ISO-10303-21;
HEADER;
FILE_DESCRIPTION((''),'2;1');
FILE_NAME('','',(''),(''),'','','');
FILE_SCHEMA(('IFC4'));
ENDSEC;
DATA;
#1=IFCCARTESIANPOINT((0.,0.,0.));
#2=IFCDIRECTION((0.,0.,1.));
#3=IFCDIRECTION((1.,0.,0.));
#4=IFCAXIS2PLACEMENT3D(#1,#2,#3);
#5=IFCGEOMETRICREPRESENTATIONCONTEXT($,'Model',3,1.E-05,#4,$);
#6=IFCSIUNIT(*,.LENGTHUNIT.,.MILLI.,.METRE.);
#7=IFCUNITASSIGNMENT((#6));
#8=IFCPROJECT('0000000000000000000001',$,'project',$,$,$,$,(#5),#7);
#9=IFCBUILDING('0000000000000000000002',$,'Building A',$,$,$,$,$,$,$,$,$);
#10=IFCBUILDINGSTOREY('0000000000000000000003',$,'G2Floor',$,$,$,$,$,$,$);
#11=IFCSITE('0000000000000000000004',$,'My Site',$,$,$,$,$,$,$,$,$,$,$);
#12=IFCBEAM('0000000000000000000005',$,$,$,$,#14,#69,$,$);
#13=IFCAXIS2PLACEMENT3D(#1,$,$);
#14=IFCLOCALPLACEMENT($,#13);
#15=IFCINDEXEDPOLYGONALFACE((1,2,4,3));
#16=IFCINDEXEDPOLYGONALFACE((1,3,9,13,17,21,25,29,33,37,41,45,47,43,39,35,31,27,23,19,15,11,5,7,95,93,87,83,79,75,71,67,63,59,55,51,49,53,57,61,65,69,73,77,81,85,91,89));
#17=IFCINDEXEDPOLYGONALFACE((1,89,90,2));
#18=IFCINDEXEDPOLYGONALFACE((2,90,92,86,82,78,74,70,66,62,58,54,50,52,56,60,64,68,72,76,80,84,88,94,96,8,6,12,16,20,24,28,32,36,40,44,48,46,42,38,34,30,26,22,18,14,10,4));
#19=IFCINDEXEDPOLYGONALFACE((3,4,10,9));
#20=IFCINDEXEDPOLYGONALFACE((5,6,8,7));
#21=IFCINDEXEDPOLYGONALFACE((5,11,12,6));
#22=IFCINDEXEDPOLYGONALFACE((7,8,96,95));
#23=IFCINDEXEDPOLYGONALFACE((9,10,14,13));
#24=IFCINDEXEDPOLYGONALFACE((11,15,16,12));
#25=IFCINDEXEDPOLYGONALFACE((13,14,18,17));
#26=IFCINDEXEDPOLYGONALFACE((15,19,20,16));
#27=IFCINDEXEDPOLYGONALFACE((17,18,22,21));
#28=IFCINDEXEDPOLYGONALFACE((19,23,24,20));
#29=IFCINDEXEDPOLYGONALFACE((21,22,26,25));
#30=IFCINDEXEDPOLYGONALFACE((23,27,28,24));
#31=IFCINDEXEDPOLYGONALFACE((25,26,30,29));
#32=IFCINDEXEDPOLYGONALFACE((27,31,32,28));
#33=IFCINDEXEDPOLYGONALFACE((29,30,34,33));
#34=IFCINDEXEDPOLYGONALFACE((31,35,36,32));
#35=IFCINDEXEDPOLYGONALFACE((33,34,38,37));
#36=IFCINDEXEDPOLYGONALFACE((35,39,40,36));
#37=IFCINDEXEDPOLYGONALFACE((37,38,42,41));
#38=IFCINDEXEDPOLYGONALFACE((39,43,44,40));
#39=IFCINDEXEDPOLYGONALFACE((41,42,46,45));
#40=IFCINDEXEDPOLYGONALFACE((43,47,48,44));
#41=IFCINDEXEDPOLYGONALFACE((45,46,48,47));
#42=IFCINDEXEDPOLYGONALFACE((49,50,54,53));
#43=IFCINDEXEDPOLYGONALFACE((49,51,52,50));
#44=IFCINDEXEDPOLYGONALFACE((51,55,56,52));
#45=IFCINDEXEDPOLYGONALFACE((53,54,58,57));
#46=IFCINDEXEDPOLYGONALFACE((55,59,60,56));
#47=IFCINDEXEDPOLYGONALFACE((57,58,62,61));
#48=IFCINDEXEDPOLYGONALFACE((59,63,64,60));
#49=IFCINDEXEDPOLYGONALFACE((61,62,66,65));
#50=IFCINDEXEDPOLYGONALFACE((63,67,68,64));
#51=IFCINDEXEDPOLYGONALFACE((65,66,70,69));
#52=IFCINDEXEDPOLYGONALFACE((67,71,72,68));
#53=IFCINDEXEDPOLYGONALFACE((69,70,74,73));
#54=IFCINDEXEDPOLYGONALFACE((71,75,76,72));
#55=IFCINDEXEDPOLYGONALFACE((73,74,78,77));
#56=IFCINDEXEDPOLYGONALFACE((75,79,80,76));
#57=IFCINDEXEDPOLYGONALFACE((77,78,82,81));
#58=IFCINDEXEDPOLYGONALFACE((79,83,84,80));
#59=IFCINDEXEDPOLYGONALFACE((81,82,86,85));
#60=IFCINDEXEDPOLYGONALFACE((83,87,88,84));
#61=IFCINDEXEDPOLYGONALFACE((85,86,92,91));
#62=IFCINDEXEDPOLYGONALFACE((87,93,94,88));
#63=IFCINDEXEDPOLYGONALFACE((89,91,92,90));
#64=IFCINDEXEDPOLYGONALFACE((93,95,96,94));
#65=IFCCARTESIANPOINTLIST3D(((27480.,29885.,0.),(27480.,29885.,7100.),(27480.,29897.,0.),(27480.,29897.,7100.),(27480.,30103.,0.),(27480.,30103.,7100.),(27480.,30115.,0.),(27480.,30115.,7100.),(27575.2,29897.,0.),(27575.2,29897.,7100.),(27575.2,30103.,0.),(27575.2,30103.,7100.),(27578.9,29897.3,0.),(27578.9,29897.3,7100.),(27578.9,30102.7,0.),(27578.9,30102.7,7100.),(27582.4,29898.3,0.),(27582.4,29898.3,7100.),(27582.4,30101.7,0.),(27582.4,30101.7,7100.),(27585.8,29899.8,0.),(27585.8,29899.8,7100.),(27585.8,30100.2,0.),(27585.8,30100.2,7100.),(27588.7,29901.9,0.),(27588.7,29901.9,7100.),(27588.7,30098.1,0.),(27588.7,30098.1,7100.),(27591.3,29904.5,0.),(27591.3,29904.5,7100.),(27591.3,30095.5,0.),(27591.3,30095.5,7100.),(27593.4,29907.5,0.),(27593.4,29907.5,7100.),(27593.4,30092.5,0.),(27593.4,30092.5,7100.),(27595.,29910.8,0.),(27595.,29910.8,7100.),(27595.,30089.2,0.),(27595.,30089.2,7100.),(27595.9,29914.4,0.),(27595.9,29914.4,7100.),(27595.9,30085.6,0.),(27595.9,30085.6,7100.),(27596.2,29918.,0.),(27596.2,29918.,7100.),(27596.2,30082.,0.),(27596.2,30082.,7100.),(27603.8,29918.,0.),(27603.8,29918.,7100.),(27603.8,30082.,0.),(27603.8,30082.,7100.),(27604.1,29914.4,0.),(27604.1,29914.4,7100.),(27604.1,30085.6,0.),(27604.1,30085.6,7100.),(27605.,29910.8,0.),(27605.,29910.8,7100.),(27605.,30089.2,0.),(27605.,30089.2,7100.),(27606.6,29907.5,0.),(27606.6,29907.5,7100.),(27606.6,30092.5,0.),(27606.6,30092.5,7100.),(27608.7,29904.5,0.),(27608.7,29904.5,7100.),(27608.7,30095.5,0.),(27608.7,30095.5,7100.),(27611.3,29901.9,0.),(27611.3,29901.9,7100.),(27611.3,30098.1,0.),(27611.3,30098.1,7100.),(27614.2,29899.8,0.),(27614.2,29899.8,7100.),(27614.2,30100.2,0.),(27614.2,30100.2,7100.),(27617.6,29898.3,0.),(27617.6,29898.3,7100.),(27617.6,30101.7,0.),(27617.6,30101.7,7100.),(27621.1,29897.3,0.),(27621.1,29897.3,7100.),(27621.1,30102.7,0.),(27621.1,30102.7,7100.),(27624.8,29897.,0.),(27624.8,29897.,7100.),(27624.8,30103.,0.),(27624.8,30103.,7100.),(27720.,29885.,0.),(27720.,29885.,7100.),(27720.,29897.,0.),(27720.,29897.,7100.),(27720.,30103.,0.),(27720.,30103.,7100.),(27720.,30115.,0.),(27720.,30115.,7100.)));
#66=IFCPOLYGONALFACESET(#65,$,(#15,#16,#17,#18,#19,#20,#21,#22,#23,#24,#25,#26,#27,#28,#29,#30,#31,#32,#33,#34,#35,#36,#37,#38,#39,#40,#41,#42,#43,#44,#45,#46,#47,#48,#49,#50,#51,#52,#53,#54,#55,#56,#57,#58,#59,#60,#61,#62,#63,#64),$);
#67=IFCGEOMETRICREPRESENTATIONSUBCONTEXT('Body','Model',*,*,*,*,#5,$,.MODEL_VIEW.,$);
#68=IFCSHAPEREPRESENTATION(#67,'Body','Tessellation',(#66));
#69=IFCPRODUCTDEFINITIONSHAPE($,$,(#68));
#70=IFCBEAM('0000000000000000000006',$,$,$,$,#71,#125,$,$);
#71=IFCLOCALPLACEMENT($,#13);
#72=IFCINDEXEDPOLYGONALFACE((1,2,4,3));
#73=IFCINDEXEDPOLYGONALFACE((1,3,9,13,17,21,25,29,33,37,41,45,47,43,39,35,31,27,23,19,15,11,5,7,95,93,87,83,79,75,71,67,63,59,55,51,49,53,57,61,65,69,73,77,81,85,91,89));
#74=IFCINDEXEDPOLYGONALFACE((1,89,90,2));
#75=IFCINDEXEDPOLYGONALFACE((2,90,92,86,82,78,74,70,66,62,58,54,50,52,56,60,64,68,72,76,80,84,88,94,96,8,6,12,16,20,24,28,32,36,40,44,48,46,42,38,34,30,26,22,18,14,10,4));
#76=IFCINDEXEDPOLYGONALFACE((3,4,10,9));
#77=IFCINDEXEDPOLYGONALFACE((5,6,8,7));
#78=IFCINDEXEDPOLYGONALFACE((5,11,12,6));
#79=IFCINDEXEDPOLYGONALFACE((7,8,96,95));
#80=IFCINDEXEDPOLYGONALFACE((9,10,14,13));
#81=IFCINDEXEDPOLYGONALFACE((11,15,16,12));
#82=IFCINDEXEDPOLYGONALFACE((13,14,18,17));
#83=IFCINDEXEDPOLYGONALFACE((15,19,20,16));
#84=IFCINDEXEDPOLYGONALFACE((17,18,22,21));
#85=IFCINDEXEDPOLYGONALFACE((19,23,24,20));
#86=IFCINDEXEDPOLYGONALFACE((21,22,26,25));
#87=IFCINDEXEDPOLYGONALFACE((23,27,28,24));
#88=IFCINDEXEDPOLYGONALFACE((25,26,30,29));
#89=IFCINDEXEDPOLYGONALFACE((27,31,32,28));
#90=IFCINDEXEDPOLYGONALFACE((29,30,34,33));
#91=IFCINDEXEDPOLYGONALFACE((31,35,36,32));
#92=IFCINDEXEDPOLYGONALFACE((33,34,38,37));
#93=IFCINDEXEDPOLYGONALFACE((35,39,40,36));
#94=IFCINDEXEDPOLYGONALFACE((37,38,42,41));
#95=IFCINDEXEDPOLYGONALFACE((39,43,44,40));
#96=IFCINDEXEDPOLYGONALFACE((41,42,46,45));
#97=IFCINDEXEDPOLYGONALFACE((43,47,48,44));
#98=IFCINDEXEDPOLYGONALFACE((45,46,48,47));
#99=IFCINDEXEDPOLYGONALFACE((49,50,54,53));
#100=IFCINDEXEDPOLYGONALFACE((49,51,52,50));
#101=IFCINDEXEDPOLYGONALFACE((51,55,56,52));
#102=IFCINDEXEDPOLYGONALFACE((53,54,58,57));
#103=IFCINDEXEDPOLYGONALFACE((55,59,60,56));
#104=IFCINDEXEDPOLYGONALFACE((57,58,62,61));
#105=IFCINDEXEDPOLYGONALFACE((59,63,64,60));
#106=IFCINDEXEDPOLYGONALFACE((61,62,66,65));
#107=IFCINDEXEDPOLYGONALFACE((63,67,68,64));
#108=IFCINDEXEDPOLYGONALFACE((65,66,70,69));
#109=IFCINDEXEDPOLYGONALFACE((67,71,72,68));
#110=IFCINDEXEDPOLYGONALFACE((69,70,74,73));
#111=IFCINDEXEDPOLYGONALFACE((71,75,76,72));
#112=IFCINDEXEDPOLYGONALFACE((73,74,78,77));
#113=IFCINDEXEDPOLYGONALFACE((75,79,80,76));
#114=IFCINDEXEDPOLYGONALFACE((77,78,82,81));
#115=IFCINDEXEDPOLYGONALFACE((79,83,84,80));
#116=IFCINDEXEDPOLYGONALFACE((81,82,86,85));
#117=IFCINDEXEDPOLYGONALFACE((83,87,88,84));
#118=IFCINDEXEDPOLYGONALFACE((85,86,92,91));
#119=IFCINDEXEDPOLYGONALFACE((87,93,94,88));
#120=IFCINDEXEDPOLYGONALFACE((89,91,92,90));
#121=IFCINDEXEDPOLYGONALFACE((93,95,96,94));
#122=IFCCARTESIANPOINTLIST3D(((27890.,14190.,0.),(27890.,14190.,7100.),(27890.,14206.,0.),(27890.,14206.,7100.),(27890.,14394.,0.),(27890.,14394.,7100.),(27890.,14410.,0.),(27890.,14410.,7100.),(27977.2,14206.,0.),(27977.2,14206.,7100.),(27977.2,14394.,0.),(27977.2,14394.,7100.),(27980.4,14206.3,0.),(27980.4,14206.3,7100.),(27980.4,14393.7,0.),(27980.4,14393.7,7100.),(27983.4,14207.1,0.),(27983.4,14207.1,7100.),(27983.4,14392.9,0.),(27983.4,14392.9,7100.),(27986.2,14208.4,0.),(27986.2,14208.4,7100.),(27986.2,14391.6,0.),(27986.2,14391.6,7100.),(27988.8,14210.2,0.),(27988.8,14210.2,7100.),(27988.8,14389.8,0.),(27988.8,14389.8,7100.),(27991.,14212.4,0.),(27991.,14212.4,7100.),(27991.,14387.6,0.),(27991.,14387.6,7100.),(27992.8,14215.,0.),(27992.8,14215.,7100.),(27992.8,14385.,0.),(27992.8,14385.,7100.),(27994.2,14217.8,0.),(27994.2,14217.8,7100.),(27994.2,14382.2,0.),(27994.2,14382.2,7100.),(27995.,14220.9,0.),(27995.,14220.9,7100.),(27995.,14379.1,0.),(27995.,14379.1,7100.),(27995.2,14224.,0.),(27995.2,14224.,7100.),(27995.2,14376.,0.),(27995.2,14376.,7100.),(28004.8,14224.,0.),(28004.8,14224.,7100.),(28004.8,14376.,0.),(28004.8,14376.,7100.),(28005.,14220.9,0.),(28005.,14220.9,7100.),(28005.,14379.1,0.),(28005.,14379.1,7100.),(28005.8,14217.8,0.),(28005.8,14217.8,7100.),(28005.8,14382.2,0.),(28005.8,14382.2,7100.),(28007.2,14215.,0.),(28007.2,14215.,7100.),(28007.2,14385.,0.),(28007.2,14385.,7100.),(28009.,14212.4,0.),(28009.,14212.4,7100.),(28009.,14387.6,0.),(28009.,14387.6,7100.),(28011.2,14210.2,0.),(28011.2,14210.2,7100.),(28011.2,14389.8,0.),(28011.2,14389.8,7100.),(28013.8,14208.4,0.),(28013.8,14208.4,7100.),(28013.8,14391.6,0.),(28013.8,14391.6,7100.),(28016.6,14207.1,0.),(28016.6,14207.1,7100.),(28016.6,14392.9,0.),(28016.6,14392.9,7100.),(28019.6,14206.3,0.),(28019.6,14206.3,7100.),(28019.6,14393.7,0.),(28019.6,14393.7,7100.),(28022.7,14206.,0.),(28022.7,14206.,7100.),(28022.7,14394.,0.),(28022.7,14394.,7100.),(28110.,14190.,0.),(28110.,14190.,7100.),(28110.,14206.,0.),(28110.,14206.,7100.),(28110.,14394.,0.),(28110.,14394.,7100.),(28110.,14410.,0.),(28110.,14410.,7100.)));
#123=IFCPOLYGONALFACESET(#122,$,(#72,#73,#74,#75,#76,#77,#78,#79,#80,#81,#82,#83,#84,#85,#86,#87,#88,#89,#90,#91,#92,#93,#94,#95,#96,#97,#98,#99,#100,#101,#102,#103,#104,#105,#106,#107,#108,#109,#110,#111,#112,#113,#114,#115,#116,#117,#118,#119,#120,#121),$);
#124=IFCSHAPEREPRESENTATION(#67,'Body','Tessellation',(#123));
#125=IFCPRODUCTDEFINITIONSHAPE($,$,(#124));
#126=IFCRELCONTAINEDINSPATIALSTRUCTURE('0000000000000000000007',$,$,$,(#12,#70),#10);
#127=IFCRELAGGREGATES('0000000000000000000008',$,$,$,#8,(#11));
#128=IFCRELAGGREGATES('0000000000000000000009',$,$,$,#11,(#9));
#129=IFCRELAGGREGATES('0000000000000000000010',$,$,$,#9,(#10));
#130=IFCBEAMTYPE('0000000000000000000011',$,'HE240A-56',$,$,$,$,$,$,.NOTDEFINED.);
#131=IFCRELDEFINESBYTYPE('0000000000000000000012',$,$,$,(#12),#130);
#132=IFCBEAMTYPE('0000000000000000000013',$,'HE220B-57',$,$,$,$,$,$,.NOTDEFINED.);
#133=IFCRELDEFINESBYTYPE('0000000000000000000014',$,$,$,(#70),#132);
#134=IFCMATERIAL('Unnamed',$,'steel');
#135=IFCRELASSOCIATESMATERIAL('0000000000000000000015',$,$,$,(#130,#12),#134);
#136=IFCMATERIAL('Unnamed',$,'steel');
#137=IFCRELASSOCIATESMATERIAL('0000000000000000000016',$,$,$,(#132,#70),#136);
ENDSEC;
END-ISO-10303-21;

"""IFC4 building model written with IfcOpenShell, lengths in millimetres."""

from ifc_helpers import new_model, si_unit, frame, origin_with_axes, place, context, subcontext, project, spatial, polyline, outline, extrude, material, material_profile, profile_set, profile_usage, type_object, element, save


model = new_model("IFC4")

# Units and contexts
model_context = context("Model", 3, precision=1e-05, world=origin_with_axes())
body_context = subcontext(model_context, "Body", "Model", "MODEL_VIEW")
ifc_project = project(units=[si_unit("LENGTHUNIT", "METRE", prefix="MILLI")], contexts=[model_context])

# Site, building, storey
site = spatial("IfcSite", under=ifc_project, Name="My Site")
building = spatial("IfcBuilding", under=site, Name="Building A")
storey = spatial("IfcBuildingStorey", under=building, Name="G2Floor")

# Beams
ifc_material_1 = material(Name="Unnamed", Category="steel")
ifc_material_profile_1 = material_profile(ifc_material_1, outline(polyline([(120.0, -115.0), (120.0, -103.0), (120.0, -103.0), (24.8, -103.0), (24.8, -103.0), (21.1, -102.7), (21.1, -102.7), (17.6, -101.7), (17.6, -101.7), (14.2, -100.2), (14.2, -100.2), (11.3, -98.1), (11.3, -98.1), (8.7, -95.5), (8.7, -95.5), (6.6, -92.5), (6.6, -92.5), (5.0, -89.2), (5.0, -89.2), (4.1, -85.6), (4.1, -85.6), (3.8, -82.0), (3.8, -82.0), (3.8, 82.0), (3.8, 82.0), (4.1, 85.6), (4.1, 85.6), (5.0, 89.2), (5.0, 89.2), (6.6, 92.5), (6.6, 92.5), (8.7, 95.5), (8.7, 95.5), (11.3, 98.1), (11.3, 98.1), (14.2, 100.2), (14.2, 100.2), (17.6, 101.7), (17.6, 101.7), (21.1, 102.7), (21.1, 102.7), (24.8, 103.0), (24.8, 103.0), (120.0, 103.0), (120.0, 103.0), (120.0, 115.0), (120.0, 115.0), (-120.0, 115.0), (-120.0, 115.0), (-120.0, 103.0), (-120.0, 103.0), (-24.8, 103.0), (-24.8, 103.0), (-21.1, 102.7), (-21.1, 102.7), (-17.6, 101.7), (-17.6, 101.7), (-14.2, 100.2), (-14.2, 100.2), (-11.3, 98.1), (-11.3, 98.1), (-8.7, 95.5), (-8.7, 95.5), (-6.6, 92.5), (-6.6, 92.5), (-5.0, 89.2), (-5.0, 89.2), (-4.1, 85.6), (-4.1, 85.6), (-3.8, 82.0), (-3.8, 82.0), (-3.8, -82.0), (-3.8, -82.0), (-4.1, -85.6), (-4.1, -85.6), (-5.0, -89.2), (-5.0, -89.2), (-6.6, -92.5), (-6.6, -92.5), (-8.7, -95.5), (-8.7, -95.5), (-11.3, -98.1), (-11.3, -98.1), (-14.2, -100.2), (-14.2, -100.2), (-17.6, -101.7), (-17.6, -101.7), (-21.1, -102.7), (-21.1, -102.7), (-24.8, -103.0), (-24.8, -103.0), (-120.0, -103.0), (-120.0, -103.0), (-120.0, -115.0), (-120.0, -115.0), (120.0, -115.0)])))
ifc_profile_set_1 = profile_set([ifc_material_profile_1], Name="HE240A-56")
ifc_profile_usage_1 = profile_usage(ifc_profile_set_1)
beam_type_1 = type_object("IfcBeamType", Name="HE240A-56", PredefinedType="NOTDEFINED", material=ifc_profile_set_1)
beam_1_placement = place(None, frame((27600.0, 30000.0, 0.0), z_axis=(0.0, 0.0, 1.0), x_axis=(1.0, 0.0, 0.0)))
element("IfcBeam", 1, at=beam_1_placement, inside=storey, type_object=beam_type_1, material=ifc_profile_usage_1, context=body_context, shape_type="SweptSolid", body=[
    extrude(outline(polyline([(120.0, -115.0), (120.0, -103.0), (120.0, -103.0), (24.8, -103.0), (24.8, -103.0), (21.1, -102.7), (21.1, -102.7), (17.6, -101.7), (17.6, -101.7), (14.2, -100.2), (14.2, -100.2), (11.3, -98.1), (11.3, -98.1), (8.7, -95.5), (8.7, -95.5), (6.6, -92.5), (6.6, -92.5), (5.0, -89.2), (5.0, -89.2), (4.1, -85.6), (4.1, -85.6), (3.8, -82.0), (3.8, -82.0), (3.8, 82.0), (3.8, 82.0), (4.1, 85.6), (4.1, 85.6), (5.0, 89.2), (5.0, 89.2), (6.6, 92.5), (6.6, 92.5), (8.7, 95.5), (8.7, 95.5), (11.3, 98.1), (11.3, 98.1), (14.2, 100.2), (14.2, 100.2), (17.6, 101.7), (17.6, 101.7), (21.1, 102.7), (21.1, 102.7), (24.8, 103.0), (24.8, 103.0), (120.0, 103.0), (120.0, 103.0), (120.0, 115.0), (120.0, 115.0), (-120.0, 115.0), (-120.0, 115.0), (-120.0, 103.0), (-120.0, 103.0), (-24.8, 103.0), (-24.8, 103.0), (-21.1, 102.7), (-21.1, 102.7), (-17.6, 101.7), (-17.6, 101.7), (-14.2, 100.2), (-14.2, 100.2), (-11.3, 98.1), (-11.3, 98.1), (-8.7, 95.5), (-8.7, 95.5), (-6.6, 92.5), (-6.6, 92.5), (-5.0, 89.2), (-5.0, 89.2), (-4.1, 85.6), (-4.1, 85.6), (-3.8, 82.0), (-3.8, 82.0), (-3.8, -82.0), (-3.8, -82.0), (-4.1, -85.6), (-4.1, -85.6), (-5.0, -89.2), (-5.0, -89.2), (-6.6, -92.5), (-6.6, -92.5), (-8.7, -95.5), (-8.7, -95.5), (-11.3, -98.1), (-11.3, -98.1), (-14.2, -100.2), (-14.2, -100.2), (-17.6, -101.7), (-17.6, -101.7), (-21.1, -102.7), (-21.1, -102.7), (-24.8, -103.0), (-24.8, -103.0), (-120.0, -103.0), (-120.0, -103.0), (-120.0, -115.0), (-120.0, -115.0), (120.0, -115.0)])), origin_with_axes(), (0.0, 0.0, 1.0), 7100.0),
])
ifc_material_2 = material(Name="Unnamed", Category="steel")
ifc_material_profile_2 = material_profile(ifc_material_2, outline(polyline([(110.0, -110.0), (110.0, -94.0), (110.0, -94.0), (22.8, -94.0), (22.8, -94.0), (19.6, -93.7), (19.6, -93.7), (16.6, -92.9), (16.6, -92.9), (13.8, -91.6), (13.8, -91.6), (11.2, -89.8), (11.2, -89.8), (9.0, -87.6), (9.0, -87.6), (7.2, -85.0), (7.2, -85.0), (5.8, -82.2), (5.8, -82.2), (5.0, -79.1), (5.0, -79.1), (4.8, -76.0), (4.8, -76.0), (4.8, 76.0), (4.8, 76.0), (5.0, 79.1), (5.0, 79.1), (5.8, 82.2), (5.8, 82.2), (7.2, 85.0), (7.2, 85.0), (9.0, 87.6), (9.0, 87.6), (11.2, 89.8), (11.2, 89.8), (13.8, 91.6), (13.8, 91.6), (16.6, 92.9), (16.6, 92.9), (19.6, 93.7), (19.6, 93.7), (22.8, 94.0), (22.8, 94.0), (110.0, 94.0), (110.0, 94.0), (110.0, 110.0), (110.0, 110.0), (-110.0, 110.0), (-110.0, 110.0), (-110.0, 94.0), (-110.0, 94.0), (-22.8, 94.0), (-22.8, 94.0), (-19.6, 93.7), (-19.6, 93.7), (-16.6, 92.9), (-16.6, 92.9), (-13.8, 91.6), (-13.8, 91.6), (-11.2, 89.8), (-11.2, 89.8), (-9.0, 87.6), (-9.0, 87.6), (-7.2, 85.0), (-7.2, 85.0), (-5.8, 82.2), (-5.8, 82.2), (-5.0, 79.1), (-5.0, 79.1), (-4.8, 76.0), (-4.8, 76.0), (-4.8, -76.0), (-4.8, -76.0), (-5.0, -79.1), (-5.0, -79.1), (-5.8, -82.2), (-5.8, -82.2), (-7.2, -85.0), (-7.2, -85.0), (-9.0, -87.6), (-9.0, -87.6), (-11.2, -89.8), (-11.2, -89.8), (-13.8, -91.6), (-13.8, -91.6), (-16.6, -92.9), (-16.6, -92.9), (-19.6, -93.7), (-19.6, -93.7), (-22.8, -94.0), (-22.8, -94.0), (-110.0, -94.0), (-110.0, -94.0), (-110.0, -110.0), (-110.0, -110.0), (110.0, -110.0)])))
ifc_profile_set_2 = profile_set([ifc_material_profile_2], Name="HE220B-57")
ifc_profile_usage_2 = profile_usage(ifc_profile_set_2)
beam_type_2 = type_object("IfcBeamType", Name="HE220B-57", PredefinedType="NOTDEFINED", material=ifc_profile_set_2)
beam_2_placement = place(None, frame((28000.0, 14300.0, 0.0), z_axis=(0.0, 0.0, 1.0), x_axis=(1.0, 0.0, 0.0)))
element("IfcBeam", 2, at=beam_2_placement, inside=storey, type_object=beam_type_2, material=ifc_profile_usage_2, context=body_context, shape_type="SweptSolid", body=[
    extrude(outline(polyline([(110.0, -110.0), (110.0, -94.0), (110.0, -94.0), (22.8, -94.0), (22.8, -94.0), (19.6, -93.7), (19.6, -93.7), (16.6, -92.9), (16.6, -92.9), (13.8, -91.6), (13.8, -91.6), (11.2, -89.8), (11.2, -89.8), (9.0, -87.6), (9.0, -87.6), (7.2, -85.0), (7.2, -85.0), (5.8, -82.2), (5.8, -82.2), (5.0, -79.1), (5.0, -79.1), (4.8, -76.0), (4.8, -76.0), (4.8, 76.0), (4.8, 76.0), (5.0, 79.1), (5.0, 79.1), (5.8, 82.2), (5.8, 82.2), (7.2, 85.0), (7.2, 85.0), (9.0, 87.6), (9.0, 87.6), (11.2, 89.8), (11.2, 89.8), (13.8, 91.6), (13.8, 91.6), (16.6, 92.9), (16.6, 92.9), (19.6, 93.7), (19.6, 93.7), (22.8, 94.0), (22.8, 94.0), (110.0, 94.0), (110.0, 94.0), (110.0, 110.0), (110.0, 110.0), (-110.0, 110.0), (-110.0, 110.0), (-110.0, 94.0), (-110.0, 94.0), (-22.8, 94.0), (-22.8, 94.0), (-19.6, 93.7), (-19.6, 93.7), (-16.6, 92.9), (-16.6, 92.9), (-13.8, 91.6), (-13.8, 91.6), (-11.2, 89.8), (-11.2, 89.8), (-9.0, 87.6), (-9.0, 87.6), (-7.2, 85.0), (-7.2, 85.0), (-5.8, 82.2), (-5.8, 82.2), (-5.0, 79.1), (-5.0, 79.1), (-4.8, 76.0), (-4.8, 76.0), (-4.8, -76.0), (-4.8, -76.0), (-5.0, -79.1), (-5.0, -79.1), (-5.8, -82.2), (-5.8, -82.2), (-7.2, -85.0), (-7.2, -85.0), (-9.0, -87.6), (-9.0, -87.6), (-11.2, -89.8), (-11.2, -89.8), (-13.8, -91.6), (-13.8, -91.6), (-16.6, -92.9), (-16.6, -92.9), (-19.6, -93.7), (-19.6, -93.7), (-22.8, -94.0), (-22.8, -94.0), (-110.0, -94.0), (-110.0, -94.0), (-110.0, -110.0), (-110.0, -110.0), (110.0, -110.0)])), origin_with_axes(), (0.0, 0.0, 1.0), 7100.0),
])

save(model, "model.ifc")
